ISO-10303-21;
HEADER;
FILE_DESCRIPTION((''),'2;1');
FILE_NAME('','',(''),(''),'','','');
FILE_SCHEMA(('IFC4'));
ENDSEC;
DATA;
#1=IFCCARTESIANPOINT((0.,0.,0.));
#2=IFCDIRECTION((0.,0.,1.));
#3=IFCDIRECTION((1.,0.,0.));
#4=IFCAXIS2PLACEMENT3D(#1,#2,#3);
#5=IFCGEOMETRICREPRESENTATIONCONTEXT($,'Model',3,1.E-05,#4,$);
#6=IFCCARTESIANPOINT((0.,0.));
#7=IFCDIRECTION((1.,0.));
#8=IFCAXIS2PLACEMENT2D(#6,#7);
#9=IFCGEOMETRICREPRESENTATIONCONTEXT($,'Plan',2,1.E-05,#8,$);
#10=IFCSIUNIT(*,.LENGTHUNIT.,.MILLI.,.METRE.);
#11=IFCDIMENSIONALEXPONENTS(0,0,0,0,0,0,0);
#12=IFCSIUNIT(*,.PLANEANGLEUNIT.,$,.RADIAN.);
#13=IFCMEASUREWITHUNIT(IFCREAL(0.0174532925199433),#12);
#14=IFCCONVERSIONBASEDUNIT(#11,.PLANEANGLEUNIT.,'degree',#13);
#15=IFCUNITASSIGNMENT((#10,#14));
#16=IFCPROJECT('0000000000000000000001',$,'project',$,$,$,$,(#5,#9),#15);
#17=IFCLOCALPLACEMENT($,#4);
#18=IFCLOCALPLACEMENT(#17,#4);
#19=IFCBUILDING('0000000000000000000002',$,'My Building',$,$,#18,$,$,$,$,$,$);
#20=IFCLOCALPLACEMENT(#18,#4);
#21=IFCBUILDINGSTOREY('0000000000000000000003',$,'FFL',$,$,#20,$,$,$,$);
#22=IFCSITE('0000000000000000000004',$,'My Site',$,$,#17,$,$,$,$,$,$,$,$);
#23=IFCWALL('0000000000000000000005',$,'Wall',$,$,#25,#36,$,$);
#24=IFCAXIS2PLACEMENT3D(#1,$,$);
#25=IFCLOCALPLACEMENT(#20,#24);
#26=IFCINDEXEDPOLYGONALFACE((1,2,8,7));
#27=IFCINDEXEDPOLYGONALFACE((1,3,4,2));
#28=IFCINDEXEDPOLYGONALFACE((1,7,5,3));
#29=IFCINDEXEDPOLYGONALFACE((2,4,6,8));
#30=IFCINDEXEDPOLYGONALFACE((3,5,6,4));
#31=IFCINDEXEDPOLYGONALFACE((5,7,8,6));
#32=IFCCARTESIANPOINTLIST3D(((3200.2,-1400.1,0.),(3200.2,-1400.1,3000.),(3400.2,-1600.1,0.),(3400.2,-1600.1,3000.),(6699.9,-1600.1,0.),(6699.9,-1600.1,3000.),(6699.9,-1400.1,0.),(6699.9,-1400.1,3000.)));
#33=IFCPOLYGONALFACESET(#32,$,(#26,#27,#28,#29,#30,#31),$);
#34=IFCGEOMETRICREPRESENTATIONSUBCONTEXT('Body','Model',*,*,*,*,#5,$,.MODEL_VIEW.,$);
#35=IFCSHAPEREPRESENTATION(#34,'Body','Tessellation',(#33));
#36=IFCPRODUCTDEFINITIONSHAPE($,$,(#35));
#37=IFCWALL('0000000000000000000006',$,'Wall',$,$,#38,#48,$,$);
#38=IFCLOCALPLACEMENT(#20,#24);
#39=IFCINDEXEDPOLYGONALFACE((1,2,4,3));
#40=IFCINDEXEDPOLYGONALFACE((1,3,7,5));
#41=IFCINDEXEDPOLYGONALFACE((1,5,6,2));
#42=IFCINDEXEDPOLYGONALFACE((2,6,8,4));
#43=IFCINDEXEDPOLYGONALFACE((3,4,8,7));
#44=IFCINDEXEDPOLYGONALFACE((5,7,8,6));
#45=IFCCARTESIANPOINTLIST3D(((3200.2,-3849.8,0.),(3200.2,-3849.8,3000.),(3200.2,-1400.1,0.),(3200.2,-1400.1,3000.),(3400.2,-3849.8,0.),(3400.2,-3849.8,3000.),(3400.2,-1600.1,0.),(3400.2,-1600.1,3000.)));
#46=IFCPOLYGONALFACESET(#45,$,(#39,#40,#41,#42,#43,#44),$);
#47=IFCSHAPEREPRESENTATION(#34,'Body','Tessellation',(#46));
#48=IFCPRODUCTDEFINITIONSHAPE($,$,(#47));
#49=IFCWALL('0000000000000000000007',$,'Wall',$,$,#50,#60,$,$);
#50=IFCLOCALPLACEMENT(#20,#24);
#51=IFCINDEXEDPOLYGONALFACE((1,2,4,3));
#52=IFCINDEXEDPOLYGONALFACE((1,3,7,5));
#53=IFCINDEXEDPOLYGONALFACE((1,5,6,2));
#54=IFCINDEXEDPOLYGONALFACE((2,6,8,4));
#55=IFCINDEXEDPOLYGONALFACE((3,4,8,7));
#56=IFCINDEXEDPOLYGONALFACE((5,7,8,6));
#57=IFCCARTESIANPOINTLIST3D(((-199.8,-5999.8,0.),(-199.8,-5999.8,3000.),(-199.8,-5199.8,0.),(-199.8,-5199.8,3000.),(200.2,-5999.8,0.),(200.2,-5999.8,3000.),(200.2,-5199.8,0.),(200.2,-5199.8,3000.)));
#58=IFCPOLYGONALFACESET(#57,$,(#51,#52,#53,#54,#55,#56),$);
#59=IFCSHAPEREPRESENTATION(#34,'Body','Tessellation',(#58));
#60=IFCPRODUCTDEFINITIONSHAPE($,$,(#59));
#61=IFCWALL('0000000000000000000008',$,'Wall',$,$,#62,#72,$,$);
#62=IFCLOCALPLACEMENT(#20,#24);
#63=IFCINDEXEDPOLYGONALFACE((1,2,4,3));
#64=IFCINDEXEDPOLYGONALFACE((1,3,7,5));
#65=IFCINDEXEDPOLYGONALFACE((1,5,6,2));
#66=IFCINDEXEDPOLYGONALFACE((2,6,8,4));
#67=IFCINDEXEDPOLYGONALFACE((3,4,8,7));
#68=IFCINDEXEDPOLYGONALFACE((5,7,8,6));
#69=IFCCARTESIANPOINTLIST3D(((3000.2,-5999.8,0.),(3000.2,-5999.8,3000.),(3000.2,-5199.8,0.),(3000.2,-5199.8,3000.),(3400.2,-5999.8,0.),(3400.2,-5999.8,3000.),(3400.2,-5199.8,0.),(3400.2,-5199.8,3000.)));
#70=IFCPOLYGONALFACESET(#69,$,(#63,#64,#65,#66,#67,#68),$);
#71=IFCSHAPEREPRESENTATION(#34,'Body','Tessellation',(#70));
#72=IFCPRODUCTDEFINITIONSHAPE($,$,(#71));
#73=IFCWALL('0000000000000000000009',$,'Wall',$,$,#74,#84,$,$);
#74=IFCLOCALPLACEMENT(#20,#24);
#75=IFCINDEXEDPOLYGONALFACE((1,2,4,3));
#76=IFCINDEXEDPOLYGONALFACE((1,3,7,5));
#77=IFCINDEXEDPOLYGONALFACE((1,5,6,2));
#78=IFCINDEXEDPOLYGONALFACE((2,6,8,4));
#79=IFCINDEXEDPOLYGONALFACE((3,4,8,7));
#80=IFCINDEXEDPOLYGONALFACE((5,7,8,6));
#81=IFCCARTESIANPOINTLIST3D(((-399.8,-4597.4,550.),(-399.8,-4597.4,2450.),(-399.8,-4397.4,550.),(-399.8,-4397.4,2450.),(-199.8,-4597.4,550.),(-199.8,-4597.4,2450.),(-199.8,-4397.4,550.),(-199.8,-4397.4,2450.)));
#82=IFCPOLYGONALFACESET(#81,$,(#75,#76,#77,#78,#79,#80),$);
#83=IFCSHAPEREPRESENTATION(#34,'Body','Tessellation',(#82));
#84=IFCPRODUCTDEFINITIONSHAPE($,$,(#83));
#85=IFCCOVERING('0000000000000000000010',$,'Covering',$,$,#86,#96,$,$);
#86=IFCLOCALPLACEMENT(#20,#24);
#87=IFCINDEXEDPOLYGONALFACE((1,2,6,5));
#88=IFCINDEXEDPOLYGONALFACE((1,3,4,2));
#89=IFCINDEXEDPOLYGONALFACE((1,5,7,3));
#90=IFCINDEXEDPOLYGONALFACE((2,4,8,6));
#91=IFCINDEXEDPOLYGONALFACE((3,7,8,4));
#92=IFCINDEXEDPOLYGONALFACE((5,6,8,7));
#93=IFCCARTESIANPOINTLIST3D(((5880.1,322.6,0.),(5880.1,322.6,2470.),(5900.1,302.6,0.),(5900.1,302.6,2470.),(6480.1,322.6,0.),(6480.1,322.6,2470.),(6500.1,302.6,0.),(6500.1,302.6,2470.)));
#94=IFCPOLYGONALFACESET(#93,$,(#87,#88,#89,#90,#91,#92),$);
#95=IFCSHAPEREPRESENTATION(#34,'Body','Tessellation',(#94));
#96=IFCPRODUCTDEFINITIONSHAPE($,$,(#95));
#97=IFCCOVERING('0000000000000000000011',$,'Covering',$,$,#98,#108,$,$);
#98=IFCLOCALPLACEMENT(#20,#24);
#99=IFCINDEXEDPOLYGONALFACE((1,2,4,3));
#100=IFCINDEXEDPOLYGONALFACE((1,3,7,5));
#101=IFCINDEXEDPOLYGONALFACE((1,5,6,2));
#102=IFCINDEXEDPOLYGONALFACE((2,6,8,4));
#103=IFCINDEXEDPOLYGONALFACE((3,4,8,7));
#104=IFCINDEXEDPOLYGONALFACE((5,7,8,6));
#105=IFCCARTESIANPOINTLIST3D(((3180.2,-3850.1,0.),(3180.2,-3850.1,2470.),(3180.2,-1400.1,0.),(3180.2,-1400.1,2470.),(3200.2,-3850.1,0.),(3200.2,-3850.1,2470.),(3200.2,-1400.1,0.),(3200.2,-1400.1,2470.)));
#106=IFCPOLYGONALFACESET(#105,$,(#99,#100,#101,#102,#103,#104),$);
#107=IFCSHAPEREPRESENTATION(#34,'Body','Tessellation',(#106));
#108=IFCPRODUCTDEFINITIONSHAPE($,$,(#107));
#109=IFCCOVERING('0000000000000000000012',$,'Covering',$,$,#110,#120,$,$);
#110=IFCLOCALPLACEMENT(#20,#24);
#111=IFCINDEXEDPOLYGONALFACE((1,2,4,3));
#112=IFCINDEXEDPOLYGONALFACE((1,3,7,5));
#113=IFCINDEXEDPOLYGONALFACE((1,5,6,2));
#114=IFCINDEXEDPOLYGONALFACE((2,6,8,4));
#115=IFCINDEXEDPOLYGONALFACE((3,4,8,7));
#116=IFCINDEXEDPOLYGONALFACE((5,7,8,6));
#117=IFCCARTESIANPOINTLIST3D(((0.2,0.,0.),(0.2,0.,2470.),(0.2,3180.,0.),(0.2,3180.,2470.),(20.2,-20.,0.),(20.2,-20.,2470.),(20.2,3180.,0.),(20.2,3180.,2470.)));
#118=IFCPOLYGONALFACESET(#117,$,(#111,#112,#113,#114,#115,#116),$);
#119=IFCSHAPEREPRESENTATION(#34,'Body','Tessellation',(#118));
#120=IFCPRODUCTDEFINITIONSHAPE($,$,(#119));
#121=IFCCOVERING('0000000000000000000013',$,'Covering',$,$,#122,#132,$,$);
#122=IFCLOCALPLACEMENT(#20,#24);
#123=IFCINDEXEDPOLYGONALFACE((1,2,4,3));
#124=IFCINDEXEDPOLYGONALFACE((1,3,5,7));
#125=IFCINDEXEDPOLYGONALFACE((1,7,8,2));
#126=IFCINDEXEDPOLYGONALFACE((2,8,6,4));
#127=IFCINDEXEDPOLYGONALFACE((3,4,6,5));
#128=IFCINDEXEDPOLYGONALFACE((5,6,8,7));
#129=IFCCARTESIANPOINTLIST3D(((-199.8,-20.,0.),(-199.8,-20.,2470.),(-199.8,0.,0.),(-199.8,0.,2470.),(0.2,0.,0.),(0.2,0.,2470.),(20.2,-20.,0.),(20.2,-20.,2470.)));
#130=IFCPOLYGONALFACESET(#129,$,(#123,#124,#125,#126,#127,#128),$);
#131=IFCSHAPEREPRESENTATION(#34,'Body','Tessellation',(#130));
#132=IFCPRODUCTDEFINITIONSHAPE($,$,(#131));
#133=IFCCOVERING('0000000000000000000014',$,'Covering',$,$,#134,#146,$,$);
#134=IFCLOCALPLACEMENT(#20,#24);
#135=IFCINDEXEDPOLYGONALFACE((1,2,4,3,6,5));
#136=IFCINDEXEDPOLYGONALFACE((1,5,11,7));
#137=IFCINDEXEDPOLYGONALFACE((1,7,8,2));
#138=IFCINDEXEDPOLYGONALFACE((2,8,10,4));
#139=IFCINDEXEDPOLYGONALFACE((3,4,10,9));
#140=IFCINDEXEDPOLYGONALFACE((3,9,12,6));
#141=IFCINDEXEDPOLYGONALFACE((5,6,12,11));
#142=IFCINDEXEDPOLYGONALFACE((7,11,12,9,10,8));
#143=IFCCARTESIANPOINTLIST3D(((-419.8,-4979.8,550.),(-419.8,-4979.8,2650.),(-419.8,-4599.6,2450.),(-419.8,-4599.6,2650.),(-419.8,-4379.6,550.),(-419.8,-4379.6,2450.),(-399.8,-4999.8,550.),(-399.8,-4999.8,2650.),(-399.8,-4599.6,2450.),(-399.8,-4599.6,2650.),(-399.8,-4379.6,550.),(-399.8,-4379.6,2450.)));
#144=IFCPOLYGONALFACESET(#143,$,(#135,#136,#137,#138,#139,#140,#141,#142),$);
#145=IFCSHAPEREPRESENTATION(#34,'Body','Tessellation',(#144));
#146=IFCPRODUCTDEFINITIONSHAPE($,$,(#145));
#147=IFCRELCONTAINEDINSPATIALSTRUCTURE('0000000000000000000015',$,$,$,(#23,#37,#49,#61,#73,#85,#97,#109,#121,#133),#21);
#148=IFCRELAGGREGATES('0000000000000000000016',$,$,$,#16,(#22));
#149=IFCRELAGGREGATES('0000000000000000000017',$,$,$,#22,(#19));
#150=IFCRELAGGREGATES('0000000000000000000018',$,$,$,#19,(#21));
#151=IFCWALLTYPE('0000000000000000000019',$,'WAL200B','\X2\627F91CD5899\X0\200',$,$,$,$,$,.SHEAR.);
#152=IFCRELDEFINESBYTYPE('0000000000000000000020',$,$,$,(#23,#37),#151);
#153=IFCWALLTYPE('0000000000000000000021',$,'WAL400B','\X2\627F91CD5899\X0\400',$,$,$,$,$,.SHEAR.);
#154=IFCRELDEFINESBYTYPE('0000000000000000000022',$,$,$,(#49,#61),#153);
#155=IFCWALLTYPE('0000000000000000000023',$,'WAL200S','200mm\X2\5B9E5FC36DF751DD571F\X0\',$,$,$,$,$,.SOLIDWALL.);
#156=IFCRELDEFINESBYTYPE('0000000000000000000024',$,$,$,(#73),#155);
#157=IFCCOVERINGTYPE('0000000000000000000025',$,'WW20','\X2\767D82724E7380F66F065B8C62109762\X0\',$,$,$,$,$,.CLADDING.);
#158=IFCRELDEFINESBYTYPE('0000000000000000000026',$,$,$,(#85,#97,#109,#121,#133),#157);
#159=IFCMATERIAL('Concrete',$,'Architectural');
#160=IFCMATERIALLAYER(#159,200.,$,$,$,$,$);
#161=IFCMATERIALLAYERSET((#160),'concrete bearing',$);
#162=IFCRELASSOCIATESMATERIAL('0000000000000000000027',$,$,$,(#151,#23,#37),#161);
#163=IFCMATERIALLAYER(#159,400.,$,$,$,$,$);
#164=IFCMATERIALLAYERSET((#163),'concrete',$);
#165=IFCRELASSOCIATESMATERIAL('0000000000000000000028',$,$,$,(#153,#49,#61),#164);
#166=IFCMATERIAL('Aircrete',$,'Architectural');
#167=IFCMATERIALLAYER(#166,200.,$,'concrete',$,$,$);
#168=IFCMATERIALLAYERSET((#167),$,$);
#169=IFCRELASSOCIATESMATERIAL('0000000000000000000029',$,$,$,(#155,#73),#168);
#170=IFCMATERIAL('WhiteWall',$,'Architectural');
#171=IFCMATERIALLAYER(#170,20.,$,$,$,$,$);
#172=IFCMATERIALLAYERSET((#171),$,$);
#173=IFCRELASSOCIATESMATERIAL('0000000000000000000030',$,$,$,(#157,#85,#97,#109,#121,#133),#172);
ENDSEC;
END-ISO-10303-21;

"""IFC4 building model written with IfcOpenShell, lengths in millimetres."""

from ifc_helpers import new_model, entity, si_unit, converted_unit, frame, origin_with_axes, origin_2d_with_axis, place, context, subcontext, project, spatial, line, indexed_curve, outline, extrude, material, layer, layer_set, layer_usage, type_object, element, save


model = new_model("IFC4")

# Units and contexts
model_context = context("Model", 3, precision=1e-05, world=origin_with_axes())
plan_context = context("Plan", 2, precision=1e-05, world=origin_2d_with_axis())
body_context_1 = subcontext(model_context, "Body", "Model", "MODEL_VIEW")
ifc_project = project(units=[si_unit("LENGTHUNIT", "METRE", prefix="MILLI"), converted_unit("PLANEANGLEUNIT", "degree", entity("IfcReal", 0.0174532925199433), si_unit("PLANEANGLEUNIT", "RADIAN"), dimensions=[0, 0, 0, 0, 0, 0, 0])], contexts=[model_context, plan_context])

# Site, building, storey
site_placement = place(None, origin_with_axes())
site = spatial("IfcSite", under=ifc_project, at=site_placement, Name="My Site")
building_placement = place(site_placement, origin_with_axes())
building = spatial("IfcBuilding", under=site, at=building_placement, Name="My Building")
storey_placement = place(building_placement, origin_with_axes())
storey = spatial("IfcBuildingStorey", under=building, at=storey_placement, Name="FFL")

# Shared definitions
ifc_material_1 = material(Name="Aircrete", Category="Architectural")

# Walls
ifc_material_2 = material(Name="Concrete", Category="Architectural")
ifc_layer_1 = layer(ifc_material_2, 200.0)
ifc_layer_set_1 = layer_set([ifc_layer_1], Name="concrete bearing")
wall_type_1 = type_object("IfcWallType", Name="WAL200B", Description="承重墙200", PredefinedType="SHEAR", material=ifc_layer_set_1)
ifc_layer_usage_1 = layer_usage(ifc_layer_set_1, "AXIS2", "NEGATIVE", 0.0)
wall_1_placement = place(storey_placement, frame((6699.9, -1600.1, 0.0), z_axis=(0.0, 0.0, 1.0), x_axis=(-1.0, 0.000006, 0.0)))
element("IfcWall", 1, at=wall_1_placement, inside=storey, type_object=wall_type_1, material=ifc_layer_usage_1, Name="Wall", context=body_context_1, shape_type="SweptSolid", body=[
    extrude(outline(indexed_curve([(0.0, -200.0), (0.0, 0.0), (3299.7, 0.0), (3499.7, -200.0)], segments=[line(1, 2, 3, 4, 1)])), origin_with_axes(), (0.0, 0.0, 1.0), 3000.0),
])
ifc_layer_usage_2 = layer_usage(ifc_layer_set_1, "AXIS2", "NEGATIVE", 0.0)
wall_2_placement = place(storey_placement, frame((3200.2, -3849.8, 0.0), z_axis=(0.0, 0.0, 1.0), x_axis=(0.0, 1.0, 0.0)))
element("IfcWall", 2, at=wall_2_placement, inside=storey, type_object=wall_type_1, material=ifc_layer_usage_2, Name="Wall", context=body_context_1, shape_type="SweptSolid", body=[
    extrude(outline(indexed_curve([(0.0, -200.0), (0.0, 0.0), (2449.7, 0.0), (2249.7, -200.0)], segments=[line(1, 2, 3, 4, 1)])), origin_with_axes(), (0.0, 0.0, 1.0), 3000.0),
])
ifc_layer_2 = layer(ifc_material_2, 400.0)
ifc_layer_set_2 = layer_set([ifc_layer_2], Name="concrete")
ifc_layer_usage_3 = layer_usage(ifc_layer_set_2, "AXIS2", "POSITIVE", 0.0)
wall_type_2 = type_object("IfcWallType", Name="WAL400B", Description="承重墙400", PredefinedType="SHEAR", material=ifc_layer_set_2)
wall_3_placement = place(storey_placement, frame((-199.8, -5199.8, 0.0), z_axis=(0.0, 0.0, 1.0), x_axis=(0.0, -1.0, 0.0)))
element("IfcWall", 3, at=wall_3_placement, inside=storey, type_object=wall_type_2, material=ifc_layer_usage_3, Name="Wall", context=body_context_1, shape_type="SweptSolid", body=[
    extrude(outline(indexed_curve([(0.0, 0.0), (0.0, 400.0), (800.0, 400.0), (800.0, 0.0)], segments=[line(1, 2, 3, 4, 1)])), origin_with_axes(), (0.0, 0.0, 1.0), 3000.0),
])
ifc_layer_usage_4 = layer_usage(ifc_layer_set_2, "AXIS2", "POSITIVE", 0.0)
wall_4_placement = place(storey_placement, frame((3400.2, -5999.8, 0.0), z_axis=(0.0, 0.0, 1.0), x_axis=(0.000001, 1.0, 0.0)))
element("IfcWall", 4, at=wall_4_placement, inside=storey, type_object=wall_type_2, material=ifc_layer_usage_4, Name="Wall", context=body_context_1, shape_type="SweptSolid", body=[
    extrude(outline(indexed_curve([(0.0, 0.0), (0.0, 400.0), (800.0, 400.0), (800.0, 0.0)], segments=[line(1, 2, 3, 4, 1)])), origin_with_axes(), (0.0, 0.0, 1.0), 3000.0),
])
ifc_layer_3 = layer(ifc_material_1, 200.0, Name="concrete")
ifc_layer_set_3 = layer_set([ifc_layer_3])
ifc_layer_usage_5 = layer_usage(ifc_layer_set_3, "AXIS2", "NEGATIVE", 0.0)
wall_type_3 = type_object("IfcWallType", Name="WAL200S", Description="200mm实心混凝土", PredefinedType="SOLIDWALL", material=ifc_layer_set_3)
wall_5_placement = place(storey_placement, frame((-399.8, -4597.4, 550.0), z_axis=(0.0, 0.0, 1.0), x_axis=(-0.000002, 1.0, 0.0)))
element("IfcWall", 5, at=wall_5_placement, inside=storey, type_object=wall_type_3, material=ifc_layer_usage_5, Name="Wall", context=body_context_1, shape_type="SweptSolid", body=[
    extrude(outline(indexed_curve([(0.0, -200.0), (0.0, 0.0), (200.0, 0.0), (200.0, -200.0)], segments=[line(1, 2, 3, 4, 1)])), origin_with_axes(), (0.0, 0.0, 1.0), 1900.0),
])

# Coverings
ifc_material_3 = material(Name="WhiteWall", Category="Architectural")
ifc_layer_4 = layer(ifc_material_3, 20.0)
ifc_layer_set_4 = layer_set([ifc_layer_4])
covering_type = type_object("IfcCoveringType", Name="WW20", Description="白色乳胶漆完成面", PredefinedType="CLADDING", material=ifc_layer_set_4)
ifc_layer_usage_6 = layer_usage(ifc_layer_set_4, "AXIS2", "NEGATIVE", 0.0)
covering_1_placement = place(storey_placement, frame((6500.1, 302.6, 0.0), z_axis=(0.0, 0.0, 1.0), x_axis=(-1.0, 0.000001, 0.0)))
element("IfcCovering", 6, at=covering_1_placement, inside=storey, type_object=covering_type, material=ifc_layer_usage_6, Name="Covering", context=body_context_1, shape_type="SweptSolid", body=[
    extrude(outline(indexed_curve([(20.0, -20.0), (0.0, 0.0), (600.0, 0.0), (620.0, -20.0)], segments=[line(1, 2, 3, 4, 1)])), origin_with_axes(), (0.0, 0.0, 1.0), 2470.0),
])
ifc_layer_usage_7 = layer_usage(ifc_layer_set_4, "AXIS2", "NEGATIVE", 0.0)
covering_2_placement = place(storey_placement, frame((3200.2, -1400.1, 0.0), z_axis=(0.0, 0.0, 1.0), x_axis=(-0.000001, -1.0, 0.0)))
element("IfcCovering", 7, at=covering_2_placement, inside=storey, type_object=covering_type, material=ifc_layer_usage_7, Name="Covering", context=body_context_1, shape_type="SweptSolid", body=[
    extrude(outline(indexed_curve([(0.0, -20.0), (0.0, 0.0), (2450.0, 0.0), (2450.0, -20.0)], segments=[line(1, 2, 3, 4, 1)])), origin_with_axes(), (0.0, 0.0, 1.0), 2470.0),
])
ifc_layer_usage_8 = layer_usage(ifc_layer_set_4, "AXIS2", "NEGATIVE", 0.0)
covering_3_placement = place(storey_placement, frame((0.2, 0.0, 0.0), z_axis=(0.0, 0.0, 1.0), x_axis=(0.000001, 1.0, 0.0)))
element("IfcCovering", 8, at=covering_3_placement, inside=storey, type_object=covering_type, material=ifc_layer_usage_8, Name="Covering", context=body_context_1, shape_type="SweptSolid", body=[
    extrude(outline(indexed_curve([(-20.0, -20.0), (0.0, 0.0), (3180.0, 0.0), (3180.0, -20.0)], segments=[line(1, 2, 3, 4, 1)])), origin_with_axes(), (0.0, 0.0, 1.0), 2470.0),
])
ifc_layer_usage_9 = layer_usage(ifc_layer_set_4, "AXIS2", "NEGATIVE", 0.0)
covering_4_placement = place(storey_placement, frame((-199.8, 0.0, 0.0), z_axis=(0.0, 0.0, 1.0), x_axis=(1.0, -0.000001, 0.0)))
element("IfcCovering", 9, at=covering_4_placement, inside=storey, type_object=covering_type, material=ifc_layer_usage_9, Name="Covering", context=body_context_1, shape_type="SweptSolid", body=[
    extrude(outline(indexed_curve([(0.0, -20.0), (0.0, 0.0), (200.0, 0.0), (220.0, -20.0)], segments=[line(1, 2, 3, 4, 1)])), origin_with_axes(), (0.0, 0.0, 1.0), 2470.0),
])

# Covering, opening
ifc_layer_usage_10 = layer_usage(ifc_layer_set_4, "AXIS2", "POSITIVE", 0.0)
covering_5_placement = place(storey_placement, frame((-399.8, -4999.8, 550.0), z_axis=(0.0, 0.0, 1.0), x_axis=(0.000001, 1.0, 0.0)))
covering_5 = element("IfcCovering", 10, at=covering_5_placement, inside=storey, type_object=covering_type, material=ifc_layer_usage_10, Name="Covering", context=body_context_1, shape_type="SweptSolid", body=[
    extrude(outline(indexed_curve([(0.0, 0.0), (20.0, 20.0), (620.2, 20.0), (620.2, 0.0)], segments=[line(1, 2, 3, 4, 1)])), origin_with_axes(), (0.0, 0.0, 1.0), 2100.0),
])
opening_1_placement = place(covering_5_placement, frame((620.2, 120.0, 1900.0), z_axis=(0.000001, -1.0, 0.0), x_axis=(0.0, 0.0, 1.0)))
element("IfcOpeningElement", 11, at=opening_1_placement, cuts=covering_5, PredefinedType="OPENING", context=body_context_1, shape_type="SweptSolid", body=[
    extrude(outline(indexed_curve([(0.0, 220.0), (500.0, 220.0), (500.0, -100.0), (0.0, -100.0), (0.0, 220.0)])), origin_with_axes(), (0.0, 0.0, 1.0), 500.0),
])

save(model, "model.ifc")
